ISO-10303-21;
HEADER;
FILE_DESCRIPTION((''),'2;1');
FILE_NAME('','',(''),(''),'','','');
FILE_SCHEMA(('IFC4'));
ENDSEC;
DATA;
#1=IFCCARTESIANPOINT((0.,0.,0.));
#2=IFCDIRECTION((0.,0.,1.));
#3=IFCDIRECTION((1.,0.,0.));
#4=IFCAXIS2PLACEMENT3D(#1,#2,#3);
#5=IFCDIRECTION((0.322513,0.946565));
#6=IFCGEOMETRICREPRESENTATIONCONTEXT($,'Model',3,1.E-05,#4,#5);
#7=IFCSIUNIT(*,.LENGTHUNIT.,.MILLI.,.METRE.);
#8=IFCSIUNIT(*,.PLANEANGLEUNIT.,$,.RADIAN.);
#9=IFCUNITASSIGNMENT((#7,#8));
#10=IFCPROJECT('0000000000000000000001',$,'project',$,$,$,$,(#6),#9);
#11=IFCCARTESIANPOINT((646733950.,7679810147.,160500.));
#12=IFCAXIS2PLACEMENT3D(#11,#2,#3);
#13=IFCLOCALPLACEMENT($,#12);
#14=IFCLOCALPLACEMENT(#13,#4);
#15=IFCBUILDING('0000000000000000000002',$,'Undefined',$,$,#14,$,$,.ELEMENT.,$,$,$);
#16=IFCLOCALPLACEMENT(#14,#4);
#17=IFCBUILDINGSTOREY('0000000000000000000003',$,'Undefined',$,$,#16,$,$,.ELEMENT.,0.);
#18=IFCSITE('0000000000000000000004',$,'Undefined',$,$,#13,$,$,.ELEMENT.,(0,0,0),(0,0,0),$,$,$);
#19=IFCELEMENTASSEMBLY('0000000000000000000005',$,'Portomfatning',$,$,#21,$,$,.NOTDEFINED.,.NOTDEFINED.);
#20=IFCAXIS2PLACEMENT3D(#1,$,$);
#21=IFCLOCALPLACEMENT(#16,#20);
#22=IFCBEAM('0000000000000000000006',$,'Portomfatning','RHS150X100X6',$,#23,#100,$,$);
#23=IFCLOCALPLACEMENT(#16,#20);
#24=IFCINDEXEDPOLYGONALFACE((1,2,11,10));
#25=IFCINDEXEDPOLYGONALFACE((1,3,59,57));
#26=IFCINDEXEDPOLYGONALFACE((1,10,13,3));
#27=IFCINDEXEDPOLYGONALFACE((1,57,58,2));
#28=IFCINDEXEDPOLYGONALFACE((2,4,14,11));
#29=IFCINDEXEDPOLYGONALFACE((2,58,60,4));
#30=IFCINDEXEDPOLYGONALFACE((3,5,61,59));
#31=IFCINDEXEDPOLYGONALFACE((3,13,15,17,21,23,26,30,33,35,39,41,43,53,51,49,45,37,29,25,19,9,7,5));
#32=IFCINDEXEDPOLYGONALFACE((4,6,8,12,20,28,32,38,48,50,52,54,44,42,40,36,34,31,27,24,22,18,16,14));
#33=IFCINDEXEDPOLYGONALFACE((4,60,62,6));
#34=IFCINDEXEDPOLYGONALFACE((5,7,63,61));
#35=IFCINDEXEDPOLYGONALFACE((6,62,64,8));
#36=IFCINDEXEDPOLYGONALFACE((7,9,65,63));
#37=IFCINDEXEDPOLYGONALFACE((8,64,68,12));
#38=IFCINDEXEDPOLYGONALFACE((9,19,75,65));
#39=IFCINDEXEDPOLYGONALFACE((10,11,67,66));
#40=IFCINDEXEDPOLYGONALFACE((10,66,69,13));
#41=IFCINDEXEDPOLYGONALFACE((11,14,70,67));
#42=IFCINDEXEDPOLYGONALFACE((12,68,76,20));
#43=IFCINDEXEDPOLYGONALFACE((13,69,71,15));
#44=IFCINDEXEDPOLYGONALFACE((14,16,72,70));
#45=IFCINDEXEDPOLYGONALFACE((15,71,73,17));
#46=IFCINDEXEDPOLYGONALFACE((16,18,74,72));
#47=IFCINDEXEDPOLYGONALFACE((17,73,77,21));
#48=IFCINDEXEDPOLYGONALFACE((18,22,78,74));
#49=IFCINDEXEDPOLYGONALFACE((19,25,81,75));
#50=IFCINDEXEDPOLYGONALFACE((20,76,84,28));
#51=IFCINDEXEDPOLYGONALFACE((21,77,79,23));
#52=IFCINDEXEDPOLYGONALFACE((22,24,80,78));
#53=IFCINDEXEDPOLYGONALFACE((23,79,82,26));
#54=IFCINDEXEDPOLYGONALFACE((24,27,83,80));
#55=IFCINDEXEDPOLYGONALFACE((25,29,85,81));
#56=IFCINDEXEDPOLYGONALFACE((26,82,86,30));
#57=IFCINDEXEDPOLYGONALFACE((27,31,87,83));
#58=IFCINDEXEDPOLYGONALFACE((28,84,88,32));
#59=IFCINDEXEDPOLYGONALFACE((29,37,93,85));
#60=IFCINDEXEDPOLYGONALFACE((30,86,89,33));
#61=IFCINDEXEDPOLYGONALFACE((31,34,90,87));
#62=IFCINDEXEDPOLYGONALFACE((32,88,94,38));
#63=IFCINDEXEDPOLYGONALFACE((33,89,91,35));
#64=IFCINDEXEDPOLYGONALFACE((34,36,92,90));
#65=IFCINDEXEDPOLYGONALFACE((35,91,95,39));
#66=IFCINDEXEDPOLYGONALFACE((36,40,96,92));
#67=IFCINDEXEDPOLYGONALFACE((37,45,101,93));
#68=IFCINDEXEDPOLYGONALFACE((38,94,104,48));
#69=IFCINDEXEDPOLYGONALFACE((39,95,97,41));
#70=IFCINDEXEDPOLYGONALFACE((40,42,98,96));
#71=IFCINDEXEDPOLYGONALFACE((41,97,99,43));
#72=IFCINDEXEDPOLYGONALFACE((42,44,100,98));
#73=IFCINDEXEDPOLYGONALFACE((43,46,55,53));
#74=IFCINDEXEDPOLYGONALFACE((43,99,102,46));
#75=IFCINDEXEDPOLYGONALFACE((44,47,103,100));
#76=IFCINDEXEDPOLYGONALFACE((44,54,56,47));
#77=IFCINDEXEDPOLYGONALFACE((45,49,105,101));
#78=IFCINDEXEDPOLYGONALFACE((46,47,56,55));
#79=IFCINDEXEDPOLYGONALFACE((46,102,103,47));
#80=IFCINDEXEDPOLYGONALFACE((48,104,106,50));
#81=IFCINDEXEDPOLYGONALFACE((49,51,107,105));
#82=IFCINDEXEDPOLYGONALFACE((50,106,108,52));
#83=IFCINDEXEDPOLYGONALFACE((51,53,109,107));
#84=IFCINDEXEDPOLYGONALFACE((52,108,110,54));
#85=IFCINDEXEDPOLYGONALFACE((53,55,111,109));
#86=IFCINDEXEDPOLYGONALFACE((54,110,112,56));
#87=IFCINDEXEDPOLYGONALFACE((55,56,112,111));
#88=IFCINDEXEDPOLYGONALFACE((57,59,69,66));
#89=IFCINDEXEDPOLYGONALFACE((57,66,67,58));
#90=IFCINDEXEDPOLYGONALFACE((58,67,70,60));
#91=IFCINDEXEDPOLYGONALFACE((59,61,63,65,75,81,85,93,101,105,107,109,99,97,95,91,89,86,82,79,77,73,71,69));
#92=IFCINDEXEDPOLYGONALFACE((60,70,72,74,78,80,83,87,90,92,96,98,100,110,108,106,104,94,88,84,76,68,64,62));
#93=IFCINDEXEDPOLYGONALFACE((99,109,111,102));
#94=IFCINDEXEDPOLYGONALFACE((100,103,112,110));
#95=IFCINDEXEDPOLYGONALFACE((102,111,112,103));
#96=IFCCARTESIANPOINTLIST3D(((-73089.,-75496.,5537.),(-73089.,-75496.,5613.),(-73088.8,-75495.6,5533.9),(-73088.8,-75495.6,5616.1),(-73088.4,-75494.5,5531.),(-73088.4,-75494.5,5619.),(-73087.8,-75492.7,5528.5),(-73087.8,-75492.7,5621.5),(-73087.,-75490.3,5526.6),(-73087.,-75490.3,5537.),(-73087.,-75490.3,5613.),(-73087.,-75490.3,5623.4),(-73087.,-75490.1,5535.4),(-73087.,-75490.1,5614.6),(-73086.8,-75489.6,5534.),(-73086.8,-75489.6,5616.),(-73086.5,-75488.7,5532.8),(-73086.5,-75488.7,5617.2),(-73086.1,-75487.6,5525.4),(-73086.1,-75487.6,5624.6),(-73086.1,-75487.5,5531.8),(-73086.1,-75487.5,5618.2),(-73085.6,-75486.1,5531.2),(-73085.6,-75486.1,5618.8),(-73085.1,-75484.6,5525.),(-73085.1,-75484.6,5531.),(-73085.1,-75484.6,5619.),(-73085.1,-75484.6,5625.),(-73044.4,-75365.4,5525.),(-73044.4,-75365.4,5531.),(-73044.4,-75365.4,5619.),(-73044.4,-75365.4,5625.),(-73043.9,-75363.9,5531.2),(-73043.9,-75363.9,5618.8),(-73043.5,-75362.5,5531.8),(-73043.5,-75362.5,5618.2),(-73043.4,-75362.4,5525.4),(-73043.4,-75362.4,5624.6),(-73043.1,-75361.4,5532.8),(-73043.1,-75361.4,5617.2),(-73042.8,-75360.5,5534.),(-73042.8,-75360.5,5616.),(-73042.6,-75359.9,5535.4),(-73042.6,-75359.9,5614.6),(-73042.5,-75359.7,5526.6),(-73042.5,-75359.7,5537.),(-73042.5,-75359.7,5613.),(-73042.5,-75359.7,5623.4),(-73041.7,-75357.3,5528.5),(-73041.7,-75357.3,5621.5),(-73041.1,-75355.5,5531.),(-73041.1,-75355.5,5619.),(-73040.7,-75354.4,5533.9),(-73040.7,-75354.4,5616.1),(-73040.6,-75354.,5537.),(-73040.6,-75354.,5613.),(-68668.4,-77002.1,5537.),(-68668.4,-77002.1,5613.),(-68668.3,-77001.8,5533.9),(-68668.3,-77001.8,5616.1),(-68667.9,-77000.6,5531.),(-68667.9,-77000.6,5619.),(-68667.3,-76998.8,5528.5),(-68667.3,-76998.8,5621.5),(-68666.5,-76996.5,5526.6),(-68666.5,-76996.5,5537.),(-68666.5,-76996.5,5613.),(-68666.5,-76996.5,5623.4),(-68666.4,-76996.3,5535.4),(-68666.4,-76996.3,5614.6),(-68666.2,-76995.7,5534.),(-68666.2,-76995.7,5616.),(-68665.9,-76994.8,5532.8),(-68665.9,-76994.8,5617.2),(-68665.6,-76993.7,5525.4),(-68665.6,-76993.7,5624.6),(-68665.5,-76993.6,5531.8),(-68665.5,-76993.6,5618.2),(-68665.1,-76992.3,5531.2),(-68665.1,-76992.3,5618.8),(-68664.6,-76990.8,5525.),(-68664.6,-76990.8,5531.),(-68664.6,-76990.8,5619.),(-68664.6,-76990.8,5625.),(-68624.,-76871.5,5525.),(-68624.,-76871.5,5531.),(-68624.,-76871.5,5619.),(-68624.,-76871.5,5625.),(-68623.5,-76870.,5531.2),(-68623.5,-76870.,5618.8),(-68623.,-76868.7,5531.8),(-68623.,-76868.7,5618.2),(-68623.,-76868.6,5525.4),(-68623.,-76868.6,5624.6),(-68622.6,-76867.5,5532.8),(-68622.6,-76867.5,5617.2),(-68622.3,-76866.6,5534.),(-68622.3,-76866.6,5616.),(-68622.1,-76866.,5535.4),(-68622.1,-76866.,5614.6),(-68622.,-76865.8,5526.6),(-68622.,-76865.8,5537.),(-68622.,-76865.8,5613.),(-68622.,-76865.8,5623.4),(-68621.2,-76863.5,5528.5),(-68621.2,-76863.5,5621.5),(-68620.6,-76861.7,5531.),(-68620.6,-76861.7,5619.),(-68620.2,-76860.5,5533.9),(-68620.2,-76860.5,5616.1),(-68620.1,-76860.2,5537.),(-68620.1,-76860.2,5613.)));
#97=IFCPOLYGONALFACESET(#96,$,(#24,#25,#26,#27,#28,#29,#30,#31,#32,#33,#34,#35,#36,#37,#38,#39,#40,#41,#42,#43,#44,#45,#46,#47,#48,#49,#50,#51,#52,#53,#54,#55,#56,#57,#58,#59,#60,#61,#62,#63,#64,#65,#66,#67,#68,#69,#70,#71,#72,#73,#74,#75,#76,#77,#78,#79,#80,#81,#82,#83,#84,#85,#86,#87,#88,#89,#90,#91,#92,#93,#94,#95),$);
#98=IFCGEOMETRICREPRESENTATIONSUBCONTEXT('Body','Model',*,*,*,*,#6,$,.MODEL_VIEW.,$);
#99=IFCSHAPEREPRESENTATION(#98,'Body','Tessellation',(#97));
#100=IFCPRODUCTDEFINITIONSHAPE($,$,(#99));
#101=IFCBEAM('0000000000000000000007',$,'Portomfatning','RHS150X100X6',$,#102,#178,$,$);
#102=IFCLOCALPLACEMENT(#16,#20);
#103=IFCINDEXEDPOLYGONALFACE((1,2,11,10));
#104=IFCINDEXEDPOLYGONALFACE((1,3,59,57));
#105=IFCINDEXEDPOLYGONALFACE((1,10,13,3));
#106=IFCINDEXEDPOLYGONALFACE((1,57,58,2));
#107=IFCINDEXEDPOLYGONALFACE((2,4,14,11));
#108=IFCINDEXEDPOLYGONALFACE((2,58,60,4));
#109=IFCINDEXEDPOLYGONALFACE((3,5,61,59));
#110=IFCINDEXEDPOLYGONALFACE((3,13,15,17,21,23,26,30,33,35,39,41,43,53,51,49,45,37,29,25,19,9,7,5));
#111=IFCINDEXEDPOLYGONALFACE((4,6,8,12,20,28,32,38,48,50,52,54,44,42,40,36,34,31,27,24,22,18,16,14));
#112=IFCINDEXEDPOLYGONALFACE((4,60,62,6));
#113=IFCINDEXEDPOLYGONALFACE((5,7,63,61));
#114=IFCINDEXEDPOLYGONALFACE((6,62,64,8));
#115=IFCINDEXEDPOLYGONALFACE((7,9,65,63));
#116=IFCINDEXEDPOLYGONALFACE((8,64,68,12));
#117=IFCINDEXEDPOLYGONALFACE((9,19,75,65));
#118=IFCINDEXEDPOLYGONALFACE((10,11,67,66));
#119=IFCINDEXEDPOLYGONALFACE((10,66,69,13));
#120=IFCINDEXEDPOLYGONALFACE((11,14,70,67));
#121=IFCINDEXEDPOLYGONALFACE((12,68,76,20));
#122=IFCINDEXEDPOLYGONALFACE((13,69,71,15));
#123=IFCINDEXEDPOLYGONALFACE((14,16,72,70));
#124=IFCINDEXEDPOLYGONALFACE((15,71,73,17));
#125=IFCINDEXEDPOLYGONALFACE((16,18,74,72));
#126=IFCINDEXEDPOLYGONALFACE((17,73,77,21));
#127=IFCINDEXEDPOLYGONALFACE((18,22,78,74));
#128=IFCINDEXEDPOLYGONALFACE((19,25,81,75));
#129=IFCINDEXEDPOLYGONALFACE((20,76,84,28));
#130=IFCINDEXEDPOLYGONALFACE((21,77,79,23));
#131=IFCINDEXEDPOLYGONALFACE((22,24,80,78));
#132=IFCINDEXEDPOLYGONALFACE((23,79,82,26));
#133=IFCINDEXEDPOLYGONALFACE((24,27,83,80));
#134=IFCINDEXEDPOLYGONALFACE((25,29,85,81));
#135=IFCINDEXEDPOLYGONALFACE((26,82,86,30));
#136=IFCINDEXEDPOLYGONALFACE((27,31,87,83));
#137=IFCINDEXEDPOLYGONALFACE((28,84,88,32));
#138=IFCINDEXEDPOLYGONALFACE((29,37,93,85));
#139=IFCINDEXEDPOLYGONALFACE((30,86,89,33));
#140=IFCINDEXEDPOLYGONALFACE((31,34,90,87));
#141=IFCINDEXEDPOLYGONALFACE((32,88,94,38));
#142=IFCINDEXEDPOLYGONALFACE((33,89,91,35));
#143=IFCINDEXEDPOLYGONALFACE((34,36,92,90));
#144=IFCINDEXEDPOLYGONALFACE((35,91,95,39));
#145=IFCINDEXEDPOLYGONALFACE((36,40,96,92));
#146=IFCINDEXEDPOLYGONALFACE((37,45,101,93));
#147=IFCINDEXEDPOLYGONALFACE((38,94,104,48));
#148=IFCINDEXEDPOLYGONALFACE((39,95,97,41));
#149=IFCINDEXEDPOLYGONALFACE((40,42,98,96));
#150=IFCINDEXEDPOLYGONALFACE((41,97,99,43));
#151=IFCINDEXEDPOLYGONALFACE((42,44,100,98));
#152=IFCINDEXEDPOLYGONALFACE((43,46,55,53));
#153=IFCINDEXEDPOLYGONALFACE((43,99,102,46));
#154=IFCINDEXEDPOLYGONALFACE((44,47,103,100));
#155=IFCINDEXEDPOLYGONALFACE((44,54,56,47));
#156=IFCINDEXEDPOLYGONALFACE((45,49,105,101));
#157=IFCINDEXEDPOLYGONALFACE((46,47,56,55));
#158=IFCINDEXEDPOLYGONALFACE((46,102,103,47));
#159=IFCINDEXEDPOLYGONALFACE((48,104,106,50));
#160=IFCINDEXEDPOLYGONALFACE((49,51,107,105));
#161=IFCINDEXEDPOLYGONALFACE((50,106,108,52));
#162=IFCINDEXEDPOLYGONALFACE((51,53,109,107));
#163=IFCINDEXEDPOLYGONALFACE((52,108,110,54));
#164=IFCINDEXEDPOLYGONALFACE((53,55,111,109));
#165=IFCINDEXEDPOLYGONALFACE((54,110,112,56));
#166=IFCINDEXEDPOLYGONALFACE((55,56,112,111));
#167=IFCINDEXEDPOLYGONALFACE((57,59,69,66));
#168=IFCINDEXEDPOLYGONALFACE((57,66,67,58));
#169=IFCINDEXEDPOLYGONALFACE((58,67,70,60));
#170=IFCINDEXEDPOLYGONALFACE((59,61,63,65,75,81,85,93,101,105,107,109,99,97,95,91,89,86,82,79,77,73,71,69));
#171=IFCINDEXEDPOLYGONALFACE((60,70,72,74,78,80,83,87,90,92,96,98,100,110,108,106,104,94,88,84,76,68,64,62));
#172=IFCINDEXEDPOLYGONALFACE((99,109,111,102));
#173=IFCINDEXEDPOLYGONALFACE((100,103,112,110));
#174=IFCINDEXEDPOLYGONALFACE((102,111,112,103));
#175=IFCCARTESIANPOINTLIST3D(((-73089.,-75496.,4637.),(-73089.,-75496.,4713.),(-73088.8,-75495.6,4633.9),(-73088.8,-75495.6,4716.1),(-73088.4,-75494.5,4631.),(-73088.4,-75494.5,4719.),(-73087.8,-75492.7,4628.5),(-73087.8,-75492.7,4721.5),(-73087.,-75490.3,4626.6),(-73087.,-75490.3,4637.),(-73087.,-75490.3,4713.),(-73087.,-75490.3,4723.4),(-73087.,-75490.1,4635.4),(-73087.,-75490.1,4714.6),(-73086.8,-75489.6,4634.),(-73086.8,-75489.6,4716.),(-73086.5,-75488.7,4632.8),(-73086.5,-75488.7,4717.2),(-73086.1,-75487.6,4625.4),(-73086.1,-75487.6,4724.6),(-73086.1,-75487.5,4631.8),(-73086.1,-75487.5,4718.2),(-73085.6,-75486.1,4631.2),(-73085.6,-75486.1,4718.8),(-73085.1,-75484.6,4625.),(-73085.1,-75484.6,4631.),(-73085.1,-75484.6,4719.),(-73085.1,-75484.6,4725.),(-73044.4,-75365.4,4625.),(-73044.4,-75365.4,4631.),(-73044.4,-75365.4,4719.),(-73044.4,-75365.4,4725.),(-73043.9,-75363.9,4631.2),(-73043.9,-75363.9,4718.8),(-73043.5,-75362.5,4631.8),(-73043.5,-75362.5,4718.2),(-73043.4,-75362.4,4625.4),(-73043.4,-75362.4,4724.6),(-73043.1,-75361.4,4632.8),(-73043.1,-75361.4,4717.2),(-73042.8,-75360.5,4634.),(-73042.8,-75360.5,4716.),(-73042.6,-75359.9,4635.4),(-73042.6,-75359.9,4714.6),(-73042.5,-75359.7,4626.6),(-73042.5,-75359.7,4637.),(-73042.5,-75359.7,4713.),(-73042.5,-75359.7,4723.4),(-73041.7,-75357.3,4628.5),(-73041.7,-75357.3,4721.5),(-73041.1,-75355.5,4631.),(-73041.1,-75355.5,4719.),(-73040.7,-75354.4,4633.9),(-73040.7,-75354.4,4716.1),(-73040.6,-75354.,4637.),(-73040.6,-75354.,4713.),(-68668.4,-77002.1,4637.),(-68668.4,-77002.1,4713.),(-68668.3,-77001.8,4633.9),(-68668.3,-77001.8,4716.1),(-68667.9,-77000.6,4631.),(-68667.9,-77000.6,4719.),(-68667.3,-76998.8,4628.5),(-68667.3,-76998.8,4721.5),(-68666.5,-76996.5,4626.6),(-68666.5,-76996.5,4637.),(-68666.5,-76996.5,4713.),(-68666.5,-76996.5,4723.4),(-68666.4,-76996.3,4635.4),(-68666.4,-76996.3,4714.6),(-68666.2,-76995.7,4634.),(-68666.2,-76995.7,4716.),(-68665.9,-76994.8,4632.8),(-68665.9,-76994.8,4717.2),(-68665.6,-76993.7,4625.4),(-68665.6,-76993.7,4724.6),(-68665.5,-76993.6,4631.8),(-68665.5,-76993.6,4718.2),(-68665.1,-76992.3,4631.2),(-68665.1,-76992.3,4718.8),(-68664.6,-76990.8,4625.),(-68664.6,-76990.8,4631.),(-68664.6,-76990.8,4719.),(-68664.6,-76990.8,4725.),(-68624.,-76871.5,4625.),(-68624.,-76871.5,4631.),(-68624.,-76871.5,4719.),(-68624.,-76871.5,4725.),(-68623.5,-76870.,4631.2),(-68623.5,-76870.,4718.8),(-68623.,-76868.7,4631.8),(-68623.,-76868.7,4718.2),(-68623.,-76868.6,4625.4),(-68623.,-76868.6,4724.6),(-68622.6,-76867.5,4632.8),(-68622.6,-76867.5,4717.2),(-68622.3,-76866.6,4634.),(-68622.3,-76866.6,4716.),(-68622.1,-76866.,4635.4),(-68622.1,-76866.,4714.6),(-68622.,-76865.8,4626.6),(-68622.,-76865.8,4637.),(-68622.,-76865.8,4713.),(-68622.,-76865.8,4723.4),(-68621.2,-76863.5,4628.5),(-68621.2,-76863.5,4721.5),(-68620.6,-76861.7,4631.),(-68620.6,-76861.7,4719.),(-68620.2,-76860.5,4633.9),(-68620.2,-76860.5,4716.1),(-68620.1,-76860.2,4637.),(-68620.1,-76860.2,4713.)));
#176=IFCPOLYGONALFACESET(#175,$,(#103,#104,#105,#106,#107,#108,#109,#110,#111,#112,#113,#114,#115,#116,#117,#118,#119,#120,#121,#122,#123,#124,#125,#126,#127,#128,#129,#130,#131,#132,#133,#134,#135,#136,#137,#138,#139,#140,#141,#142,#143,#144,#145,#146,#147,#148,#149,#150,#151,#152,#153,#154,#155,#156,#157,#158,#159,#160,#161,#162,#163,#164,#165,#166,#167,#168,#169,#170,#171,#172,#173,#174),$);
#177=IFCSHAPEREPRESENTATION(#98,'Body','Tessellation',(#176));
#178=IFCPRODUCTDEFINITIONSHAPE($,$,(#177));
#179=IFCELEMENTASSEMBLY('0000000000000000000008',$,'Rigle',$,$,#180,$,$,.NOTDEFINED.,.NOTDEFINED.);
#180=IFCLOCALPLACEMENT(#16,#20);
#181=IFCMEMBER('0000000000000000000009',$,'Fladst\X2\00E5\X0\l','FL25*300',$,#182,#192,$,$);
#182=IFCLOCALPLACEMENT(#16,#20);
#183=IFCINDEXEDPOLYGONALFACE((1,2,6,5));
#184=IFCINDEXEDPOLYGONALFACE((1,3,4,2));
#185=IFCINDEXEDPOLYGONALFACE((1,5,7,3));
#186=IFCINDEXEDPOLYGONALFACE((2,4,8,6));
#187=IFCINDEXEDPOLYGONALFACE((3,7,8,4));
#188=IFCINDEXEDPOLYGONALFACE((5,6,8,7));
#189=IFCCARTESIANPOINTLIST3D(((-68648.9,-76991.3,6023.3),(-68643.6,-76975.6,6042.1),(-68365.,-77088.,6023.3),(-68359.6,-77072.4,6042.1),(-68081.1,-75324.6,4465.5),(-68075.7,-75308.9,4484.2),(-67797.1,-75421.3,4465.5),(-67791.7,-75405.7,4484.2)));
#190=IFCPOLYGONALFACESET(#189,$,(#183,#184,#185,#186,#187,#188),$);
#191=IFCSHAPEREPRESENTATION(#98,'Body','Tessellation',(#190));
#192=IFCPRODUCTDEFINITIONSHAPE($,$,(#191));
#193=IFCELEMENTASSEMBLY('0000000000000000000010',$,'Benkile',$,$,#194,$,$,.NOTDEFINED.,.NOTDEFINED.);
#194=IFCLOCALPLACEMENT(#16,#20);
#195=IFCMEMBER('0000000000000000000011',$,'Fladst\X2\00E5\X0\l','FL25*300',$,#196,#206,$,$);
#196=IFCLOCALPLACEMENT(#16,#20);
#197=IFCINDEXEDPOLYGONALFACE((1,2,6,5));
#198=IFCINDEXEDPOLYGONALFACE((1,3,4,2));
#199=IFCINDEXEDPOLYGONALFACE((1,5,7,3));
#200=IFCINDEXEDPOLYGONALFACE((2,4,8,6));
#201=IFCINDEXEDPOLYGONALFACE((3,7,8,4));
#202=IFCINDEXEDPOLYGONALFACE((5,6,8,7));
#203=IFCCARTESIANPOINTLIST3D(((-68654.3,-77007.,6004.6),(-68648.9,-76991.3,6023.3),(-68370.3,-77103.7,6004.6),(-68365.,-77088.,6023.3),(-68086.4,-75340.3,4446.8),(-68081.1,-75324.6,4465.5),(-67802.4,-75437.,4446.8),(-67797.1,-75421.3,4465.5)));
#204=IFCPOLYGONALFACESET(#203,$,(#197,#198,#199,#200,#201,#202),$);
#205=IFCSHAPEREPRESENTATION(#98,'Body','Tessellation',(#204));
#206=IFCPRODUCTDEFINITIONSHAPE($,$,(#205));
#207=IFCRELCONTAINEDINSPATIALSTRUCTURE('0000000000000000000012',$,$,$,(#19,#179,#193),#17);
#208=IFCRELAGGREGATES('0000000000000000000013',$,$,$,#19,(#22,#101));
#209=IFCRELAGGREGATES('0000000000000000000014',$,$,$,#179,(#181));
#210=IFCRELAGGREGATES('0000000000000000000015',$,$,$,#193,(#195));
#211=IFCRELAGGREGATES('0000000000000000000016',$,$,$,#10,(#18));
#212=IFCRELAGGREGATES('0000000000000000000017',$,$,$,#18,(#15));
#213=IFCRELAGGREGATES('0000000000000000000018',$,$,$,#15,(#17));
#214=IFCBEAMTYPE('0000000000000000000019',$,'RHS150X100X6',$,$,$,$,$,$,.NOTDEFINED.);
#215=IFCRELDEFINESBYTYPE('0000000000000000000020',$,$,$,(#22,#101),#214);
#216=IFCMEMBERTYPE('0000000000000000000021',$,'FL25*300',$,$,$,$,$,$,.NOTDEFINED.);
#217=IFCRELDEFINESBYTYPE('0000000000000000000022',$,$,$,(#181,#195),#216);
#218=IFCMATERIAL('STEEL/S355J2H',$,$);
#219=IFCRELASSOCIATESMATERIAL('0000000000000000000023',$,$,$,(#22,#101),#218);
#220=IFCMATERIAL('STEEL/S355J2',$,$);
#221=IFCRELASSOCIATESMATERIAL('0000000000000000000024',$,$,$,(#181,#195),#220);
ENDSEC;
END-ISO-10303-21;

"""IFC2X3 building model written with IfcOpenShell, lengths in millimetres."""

from ifc_helpers import new_model, si_unit, direction, frame, origin_with_axes, origin_2d_with_axis, place, context, subcontext, project, spatial, rectangle, hollow_rectangle, extrude, clip, halfspace, material, type_object, element, aggregate, save


model = new_model("IFC2X3")

# Units and contexts
model_context = context("Model", 3, precision=1e-05, world=origin_with_axes(), true_north=direction((0.322513, 0.946565)))
body_context = subcontext(model_context, "Body", "Model", "MODEL_VIEW")
ifc_project = project(units=[si_unit("LENGTHUNIT", "METRE", prefix="MILLI"), si_unit("PLANEANGLEUNIT", "RADIAN")], contexts=[model_context])

# Site, building, storey
site_placement = place(None, frame((646733950.0, 7679810147.0, 160500.0), z_axis=(0.0, 0.0, 1.0), x_axis=(1.0, 0.0, 0.0)))
site = spatial("IfcSite", under=ifc_project, at=site_placement, Name="Undefined", CompositionType="ELEMENT", RefLatitude=(0, 0, 0), RefLongitude=(0, 0, 0))
building_placement = place(site_placement, origin_with_axes())
building = spatial("IfcBuilding", under=site, at=building_placement, Name="Undefined", CompositionType="ELEMENT")
storey_placement = place(building_placement, origin_with_axes())
storey = spatial("IfcBuildingStorey", under=building, at=storey_placement, Name="Undefined", CompositionType="ELEMENT", Elevation=0.0)

# Element assembly
assembly_1_placement = place(storey_placement, origin_with_axes())
assembly_1 = element("IfcElementAssembly", 1, at=assembly_1_placement, inside=storey, Name="Portomfatning", AssemblyPlace="NOTDEFINED", PredefinedType="NOTDEFINED")
ifc_material_1 = material(Name="STEEL/S355J2H")

# Beams
beam_type_1 = type_object("IfcBeamType", Name="RHS150X100X6", PredefinedType="NOTDEFINED")
beam_1_placement = place(assembly_1_placement, frame((-68630.1, -76936.0, 5575.0), z_axis=(-0.322513, -0.946565, 0.0), x_axis=(-0.946565, 0.322513, 0.0)))
beam_1 = element("IfcBeam", 2, at=beam_1_placement, type_object=beam_type_1, material=ifc_material_1, Name="Portomfatning", Description="RHS150X100X6", context=body_context, shape_type="Clipping", body=[
    clip(clip(extrude(hollow_rectangle(XDim=100.0, YDim=150.0, WallThickness=6.0, InnerFilletRadius=6.0, OuterFilletRadius=12.0, at=origin_2d_with_axis()), frame((4777.5, 0.0, 0.0), z_axis=(-1.0, 0.0, 0.0), x_axis=(0.0, -1.0, 0.0)), (0.0, 0.0, 1.0), 4855.0), halfspace(frame((4685.0, -50.0, -75.0), z_axis=(-1.0, 0.0, 0.000226), x_axis=(0.0, 1.0, 0.0)), True)), halfspace(frame((15.0, 50.0, -75.0), z_axis=(1.0, 0.0, 0.000226), x_axis=(0.0, -1.0, 0.0)), True)),
])
beam_2_placement = place(assembly_1_placement, frame((-68630.1, -76936.0, 4675.0), z_axis=(-0.322513, -0.946565, 0.0), x_axis=(-0.946565, 0.322513, 0.0)))
beam_2 = element("IfcBeam", 3, at=beam_2_placement, type_object=beam_type_1, material=ifc_material_1, Name="Portomfatning", Description="RHS150X100X6", context=body_context, shape_type="Clipping", body=[
    clip(clip(extrude(hollow_rectangle(XDim=100.0, YDim=150.0, WallThickness=6.0, InnerFilletRadius=6.0, OuterFilletRadius=12.0, at=origin_2d_with_axis()), frame((4777.5, 0.0, 0.0), z_axis=(-1.0, 0.0, 0.0), x_axis=(0.0, -1.0, 0.0)), (0.0, 0.0, 1.0), 4855.0), halfspace(frame((4685.0, -50.0, -75.0), z_axis=(-1.0, 0.0, 0.000226), x_axis=(0.0, 1.0, 0.0)), True)), halfspace(frame((15.0, 50.0, -75.0), z_axis=(1.0, 0.0, 0.000226), x_axis=(0.0, -1.0, 0.0)), True)),
])

# Element assemblies, members
assembly_2_placement = place(storey_placement, origin_with_axes())
assembly_2 = element("IfcElementAssembly", 4, at=assembly_2_placement, inside=storey, Name="Rigle", AssemblyPlace="NOTDEFINED", PredefinedType="NOTDEFINED")
ifc_material_2 = material(Name="STEEL/S355J2")
member_type = type_object("IfcMemberType", Name="FL25*300", PredefinedType="NOTDEFINED")
member_1_placement = place(assembly_2_placement, frame((-68504.3, -77031.8, 6032.7), z_axis=(0.946565, -0.322513, 0.0), x_axis=(0.241548, 0.708935, -0.66262)))
member_1 = element("IfcMember", 5, at=member_1_placement, type_object=member_type, material=ifc_material_2, Name="Fladstål", Description="FL25*300", context=body_context, shape_type="SweptSolid", body=[
    extrude(rectangle(XDim=25.0, YDim=300.0, at=origin_2d_with_axis()), frame((2351.0, 0.0, 0.0), z_axis=(-1.0, 0.0, 0.0), x_axis=(0.0, -1.0, 0.0)), (0.0, 0.0, 1.0), 2351.0),
])
assembly_3_placement = place(storey_placement, origin_with_axes())
assembly_3 = element("IfcElementAssembly", 6, at=assembly_3_placement, inside=storey, Name="Benkile", AssemblyPlace="NOTDEFINED", PredefinedType="NOTDEFINED")
member_2_placement = place(assembly_3_placement, frame((-68509.6, -77047.5, 6014.0), z_axis=(0.946565, -0.322513, 0.0), x_axis=(0.241548, 0.708935, -0.66262)))
member_2 = element("IfcMember", 7, at=member_2_placement, type_object=member_type, material=ifc_material_2, Name="Fladstål", Description="FL25*300", context=body_context, shape_type="SweptSolid", body=[
    extrude(rectangle(XDim=25.0, YDim=300.0, at=origin_2d_with_axis()), frame((2351.0, 0.0, 0.0), z_axis=(-1.0, 0.0, 0.0), x_axis=(0.0, -1.0, 0.0)), (0.0, 0.0, 1.0), 2351.0),
])

aggregate(assembly_1, [beam_1, beam_2])

aggregate(assembly_2, [member_1])

aggregate(assembly_3, [member_2])

save(model, "model.ifc")
